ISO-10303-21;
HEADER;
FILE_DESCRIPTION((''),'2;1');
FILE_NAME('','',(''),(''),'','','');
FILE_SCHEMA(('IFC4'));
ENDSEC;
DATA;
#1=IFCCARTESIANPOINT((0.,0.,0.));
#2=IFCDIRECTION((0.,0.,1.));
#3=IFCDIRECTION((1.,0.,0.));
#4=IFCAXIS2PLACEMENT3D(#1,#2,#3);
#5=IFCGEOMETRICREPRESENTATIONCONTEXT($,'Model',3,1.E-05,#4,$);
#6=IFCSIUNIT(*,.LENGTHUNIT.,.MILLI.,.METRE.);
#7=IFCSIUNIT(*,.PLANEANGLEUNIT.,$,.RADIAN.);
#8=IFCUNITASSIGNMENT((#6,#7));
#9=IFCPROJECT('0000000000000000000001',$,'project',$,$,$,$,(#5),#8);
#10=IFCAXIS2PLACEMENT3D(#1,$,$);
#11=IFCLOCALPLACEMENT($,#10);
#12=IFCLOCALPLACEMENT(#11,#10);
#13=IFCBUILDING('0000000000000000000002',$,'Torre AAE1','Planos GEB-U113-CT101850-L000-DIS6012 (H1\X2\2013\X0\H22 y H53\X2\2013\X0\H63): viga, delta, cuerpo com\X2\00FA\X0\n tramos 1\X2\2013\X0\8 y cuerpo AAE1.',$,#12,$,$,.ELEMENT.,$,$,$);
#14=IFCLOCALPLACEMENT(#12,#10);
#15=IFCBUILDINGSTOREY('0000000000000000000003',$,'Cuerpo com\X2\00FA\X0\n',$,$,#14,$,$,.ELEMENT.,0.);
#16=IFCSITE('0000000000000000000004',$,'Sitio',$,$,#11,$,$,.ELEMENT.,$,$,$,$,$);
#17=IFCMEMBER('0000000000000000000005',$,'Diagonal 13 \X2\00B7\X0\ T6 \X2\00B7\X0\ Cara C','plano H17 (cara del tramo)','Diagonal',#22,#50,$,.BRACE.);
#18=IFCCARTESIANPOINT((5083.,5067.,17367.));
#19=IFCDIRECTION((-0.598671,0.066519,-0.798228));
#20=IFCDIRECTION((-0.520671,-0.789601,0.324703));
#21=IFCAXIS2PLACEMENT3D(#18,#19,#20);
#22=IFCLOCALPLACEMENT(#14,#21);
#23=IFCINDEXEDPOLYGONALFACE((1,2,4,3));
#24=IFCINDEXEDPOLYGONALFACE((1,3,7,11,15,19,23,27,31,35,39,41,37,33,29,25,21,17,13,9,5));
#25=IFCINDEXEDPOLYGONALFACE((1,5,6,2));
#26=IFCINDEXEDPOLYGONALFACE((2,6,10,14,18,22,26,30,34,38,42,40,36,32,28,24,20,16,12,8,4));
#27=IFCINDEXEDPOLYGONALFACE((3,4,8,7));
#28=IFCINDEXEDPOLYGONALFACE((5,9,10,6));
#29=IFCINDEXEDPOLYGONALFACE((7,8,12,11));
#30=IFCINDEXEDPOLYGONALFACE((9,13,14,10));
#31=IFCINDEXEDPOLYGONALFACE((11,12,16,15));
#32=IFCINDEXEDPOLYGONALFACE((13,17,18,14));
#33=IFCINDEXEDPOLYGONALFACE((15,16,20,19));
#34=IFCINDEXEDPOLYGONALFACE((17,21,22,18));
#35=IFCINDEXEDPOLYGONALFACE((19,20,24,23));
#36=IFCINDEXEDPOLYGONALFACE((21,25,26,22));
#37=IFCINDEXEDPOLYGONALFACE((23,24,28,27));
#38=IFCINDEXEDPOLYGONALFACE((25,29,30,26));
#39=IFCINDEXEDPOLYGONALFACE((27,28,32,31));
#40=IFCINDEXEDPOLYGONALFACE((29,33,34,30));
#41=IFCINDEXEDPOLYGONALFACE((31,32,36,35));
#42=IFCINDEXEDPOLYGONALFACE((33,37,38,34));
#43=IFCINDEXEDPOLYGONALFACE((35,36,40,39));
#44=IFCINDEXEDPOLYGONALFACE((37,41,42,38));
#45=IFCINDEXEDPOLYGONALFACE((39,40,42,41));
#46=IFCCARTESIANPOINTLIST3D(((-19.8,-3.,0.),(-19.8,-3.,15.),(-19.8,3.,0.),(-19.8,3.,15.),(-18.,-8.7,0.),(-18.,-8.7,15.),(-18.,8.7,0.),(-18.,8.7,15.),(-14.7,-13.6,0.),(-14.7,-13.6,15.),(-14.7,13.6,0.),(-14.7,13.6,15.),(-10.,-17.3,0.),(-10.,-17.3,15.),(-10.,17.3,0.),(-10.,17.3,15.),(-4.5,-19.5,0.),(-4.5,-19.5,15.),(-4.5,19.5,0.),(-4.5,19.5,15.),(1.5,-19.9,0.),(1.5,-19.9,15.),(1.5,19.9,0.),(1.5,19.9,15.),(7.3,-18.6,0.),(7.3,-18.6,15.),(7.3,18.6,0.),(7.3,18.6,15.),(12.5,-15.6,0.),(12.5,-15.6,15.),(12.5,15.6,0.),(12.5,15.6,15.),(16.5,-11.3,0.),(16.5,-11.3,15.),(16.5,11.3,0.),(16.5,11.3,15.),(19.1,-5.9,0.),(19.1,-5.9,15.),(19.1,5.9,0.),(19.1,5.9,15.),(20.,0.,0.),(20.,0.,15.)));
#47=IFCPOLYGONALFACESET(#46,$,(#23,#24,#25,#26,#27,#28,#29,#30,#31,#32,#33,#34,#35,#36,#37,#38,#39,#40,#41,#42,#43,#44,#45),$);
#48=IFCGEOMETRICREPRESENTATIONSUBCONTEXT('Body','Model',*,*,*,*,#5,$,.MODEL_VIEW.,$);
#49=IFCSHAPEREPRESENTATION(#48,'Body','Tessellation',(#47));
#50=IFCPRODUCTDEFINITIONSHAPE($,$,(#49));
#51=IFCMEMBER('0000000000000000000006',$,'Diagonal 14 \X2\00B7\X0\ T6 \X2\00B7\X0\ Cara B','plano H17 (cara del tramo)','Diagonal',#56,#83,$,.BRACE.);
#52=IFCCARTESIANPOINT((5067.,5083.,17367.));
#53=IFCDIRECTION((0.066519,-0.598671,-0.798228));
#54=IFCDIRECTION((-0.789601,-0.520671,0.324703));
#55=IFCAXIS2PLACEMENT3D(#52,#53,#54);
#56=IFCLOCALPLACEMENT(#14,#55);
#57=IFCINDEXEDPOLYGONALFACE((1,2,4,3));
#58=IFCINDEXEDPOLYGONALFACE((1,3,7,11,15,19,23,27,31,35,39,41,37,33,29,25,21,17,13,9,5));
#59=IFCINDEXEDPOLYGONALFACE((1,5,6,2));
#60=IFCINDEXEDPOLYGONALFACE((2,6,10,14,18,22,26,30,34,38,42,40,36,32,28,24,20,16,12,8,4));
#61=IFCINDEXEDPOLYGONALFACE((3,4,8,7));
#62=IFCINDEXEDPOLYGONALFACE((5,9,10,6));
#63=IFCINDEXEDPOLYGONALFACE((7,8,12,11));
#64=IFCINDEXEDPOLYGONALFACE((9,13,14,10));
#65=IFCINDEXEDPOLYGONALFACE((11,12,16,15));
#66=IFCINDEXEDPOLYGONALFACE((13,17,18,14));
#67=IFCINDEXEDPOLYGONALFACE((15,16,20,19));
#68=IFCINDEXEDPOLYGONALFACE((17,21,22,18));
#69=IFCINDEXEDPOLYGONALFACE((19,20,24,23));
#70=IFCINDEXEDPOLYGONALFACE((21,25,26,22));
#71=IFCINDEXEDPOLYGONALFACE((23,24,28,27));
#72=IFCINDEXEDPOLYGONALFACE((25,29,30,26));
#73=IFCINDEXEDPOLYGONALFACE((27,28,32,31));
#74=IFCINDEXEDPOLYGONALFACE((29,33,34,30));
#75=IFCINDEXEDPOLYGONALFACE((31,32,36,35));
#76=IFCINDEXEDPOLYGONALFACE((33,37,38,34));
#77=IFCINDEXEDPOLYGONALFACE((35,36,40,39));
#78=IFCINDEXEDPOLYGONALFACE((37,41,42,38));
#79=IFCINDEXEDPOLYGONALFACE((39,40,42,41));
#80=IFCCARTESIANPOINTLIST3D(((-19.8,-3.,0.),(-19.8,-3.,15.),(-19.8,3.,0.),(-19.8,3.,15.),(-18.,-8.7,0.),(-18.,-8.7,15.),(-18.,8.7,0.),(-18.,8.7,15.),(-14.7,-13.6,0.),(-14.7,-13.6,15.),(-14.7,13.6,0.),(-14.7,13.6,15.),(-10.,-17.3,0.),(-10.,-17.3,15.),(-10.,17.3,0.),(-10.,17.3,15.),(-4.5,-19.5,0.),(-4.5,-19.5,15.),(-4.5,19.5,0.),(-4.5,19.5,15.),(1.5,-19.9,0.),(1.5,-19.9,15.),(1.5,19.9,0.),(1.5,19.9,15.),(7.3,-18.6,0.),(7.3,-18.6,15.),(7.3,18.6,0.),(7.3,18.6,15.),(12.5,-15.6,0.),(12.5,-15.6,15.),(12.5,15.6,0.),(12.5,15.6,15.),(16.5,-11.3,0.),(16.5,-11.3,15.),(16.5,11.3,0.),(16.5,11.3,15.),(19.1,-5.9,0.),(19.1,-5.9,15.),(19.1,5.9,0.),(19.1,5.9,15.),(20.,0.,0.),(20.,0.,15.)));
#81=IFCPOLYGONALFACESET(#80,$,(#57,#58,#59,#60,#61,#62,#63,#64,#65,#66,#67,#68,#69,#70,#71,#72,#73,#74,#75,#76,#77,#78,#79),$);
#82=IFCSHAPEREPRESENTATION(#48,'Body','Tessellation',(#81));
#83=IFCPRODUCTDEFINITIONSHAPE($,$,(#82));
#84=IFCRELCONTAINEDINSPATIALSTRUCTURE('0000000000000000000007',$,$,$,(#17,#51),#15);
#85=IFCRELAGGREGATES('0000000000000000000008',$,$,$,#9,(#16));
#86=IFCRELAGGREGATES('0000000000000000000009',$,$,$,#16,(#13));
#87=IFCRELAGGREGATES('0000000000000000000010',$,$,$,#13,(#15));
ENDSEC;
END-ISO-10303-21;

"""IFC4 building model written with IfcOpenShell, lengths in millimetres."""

from ifc_helpers import new_model, si_unit, frame, origin, origin_with_axes, place, context, subcontext, project, spatial, circle, extrude, element, save


model = new_model("IFC4")

# Units and contexts
model_context = context("Model", 3, precision=1e-05, world=origin_with_axes())
body_context = subcontext(model_context, "Body", "Model", "MODEL_VIEW")
ifc_project = project(units=[si_unit("LENGTHUNIT", "METRE", prefix="MILLI"), si_unit("PLANEANGLEUNIT", "RADIAN")], contexts=[model_context])

# Site, building, storey
site_placement = place(None, origin())
site = spatial("IfcSite", under=ifc_project, at=site_placement, Name="Sitio", CompositionType="ELEMENT")
building_placement = place(site_placement, origin())
building = spatial("IfcBuilding", under=site, at=building_placement, Name="Torre AAE1", Description="Planos GEB-U113-CT101850-L000-DIS6012 (H1–H22 y H53–H63): viga, delta, cuerpo común tramos 1–8 y cuerpo AAE1.", CompositionType="ELEMENT")
storey_placement = place(building_placement, origin())
storey = spatial("IfcBuildingStorey", under=building, at=storey_placement, Name="Cuerpo común", CompositionType="ELEMENT", Elevation=0.0)

# Members
for number, where, z_axis, x_axis, name in (
    (1, (5083.0, 5067.0, 17367.0), (-0.598671, 0.066519, -0.798228), (-0.520671, -0.789601, 0.324703), "Diagonal 13 · T6 · Cara C"),
    (2, (5067.0, 5083.0, 17367.0), (0.066519, -0.598671, -0.798228), (-0.789601, -0.520671, 0.324703), "Diagonal 14 · T6 · Cara B"),
):
    element("IfcMember", number, at=place(storey_placement, frame(where, z_axis=z_axis, x_axis=x_axis)), inside=storey, Name=name, Description="plano H17 (cara del tramo)", ObjectType="Diagonal", PredefinedType="BRACE", context=body_context, shape_type="SweptSolid", body=[
        extrude(circle(Radius=20.0), None, (0.0, 0.0, 1.0), 15.0),
    ])

save(model, "model.ifc")
